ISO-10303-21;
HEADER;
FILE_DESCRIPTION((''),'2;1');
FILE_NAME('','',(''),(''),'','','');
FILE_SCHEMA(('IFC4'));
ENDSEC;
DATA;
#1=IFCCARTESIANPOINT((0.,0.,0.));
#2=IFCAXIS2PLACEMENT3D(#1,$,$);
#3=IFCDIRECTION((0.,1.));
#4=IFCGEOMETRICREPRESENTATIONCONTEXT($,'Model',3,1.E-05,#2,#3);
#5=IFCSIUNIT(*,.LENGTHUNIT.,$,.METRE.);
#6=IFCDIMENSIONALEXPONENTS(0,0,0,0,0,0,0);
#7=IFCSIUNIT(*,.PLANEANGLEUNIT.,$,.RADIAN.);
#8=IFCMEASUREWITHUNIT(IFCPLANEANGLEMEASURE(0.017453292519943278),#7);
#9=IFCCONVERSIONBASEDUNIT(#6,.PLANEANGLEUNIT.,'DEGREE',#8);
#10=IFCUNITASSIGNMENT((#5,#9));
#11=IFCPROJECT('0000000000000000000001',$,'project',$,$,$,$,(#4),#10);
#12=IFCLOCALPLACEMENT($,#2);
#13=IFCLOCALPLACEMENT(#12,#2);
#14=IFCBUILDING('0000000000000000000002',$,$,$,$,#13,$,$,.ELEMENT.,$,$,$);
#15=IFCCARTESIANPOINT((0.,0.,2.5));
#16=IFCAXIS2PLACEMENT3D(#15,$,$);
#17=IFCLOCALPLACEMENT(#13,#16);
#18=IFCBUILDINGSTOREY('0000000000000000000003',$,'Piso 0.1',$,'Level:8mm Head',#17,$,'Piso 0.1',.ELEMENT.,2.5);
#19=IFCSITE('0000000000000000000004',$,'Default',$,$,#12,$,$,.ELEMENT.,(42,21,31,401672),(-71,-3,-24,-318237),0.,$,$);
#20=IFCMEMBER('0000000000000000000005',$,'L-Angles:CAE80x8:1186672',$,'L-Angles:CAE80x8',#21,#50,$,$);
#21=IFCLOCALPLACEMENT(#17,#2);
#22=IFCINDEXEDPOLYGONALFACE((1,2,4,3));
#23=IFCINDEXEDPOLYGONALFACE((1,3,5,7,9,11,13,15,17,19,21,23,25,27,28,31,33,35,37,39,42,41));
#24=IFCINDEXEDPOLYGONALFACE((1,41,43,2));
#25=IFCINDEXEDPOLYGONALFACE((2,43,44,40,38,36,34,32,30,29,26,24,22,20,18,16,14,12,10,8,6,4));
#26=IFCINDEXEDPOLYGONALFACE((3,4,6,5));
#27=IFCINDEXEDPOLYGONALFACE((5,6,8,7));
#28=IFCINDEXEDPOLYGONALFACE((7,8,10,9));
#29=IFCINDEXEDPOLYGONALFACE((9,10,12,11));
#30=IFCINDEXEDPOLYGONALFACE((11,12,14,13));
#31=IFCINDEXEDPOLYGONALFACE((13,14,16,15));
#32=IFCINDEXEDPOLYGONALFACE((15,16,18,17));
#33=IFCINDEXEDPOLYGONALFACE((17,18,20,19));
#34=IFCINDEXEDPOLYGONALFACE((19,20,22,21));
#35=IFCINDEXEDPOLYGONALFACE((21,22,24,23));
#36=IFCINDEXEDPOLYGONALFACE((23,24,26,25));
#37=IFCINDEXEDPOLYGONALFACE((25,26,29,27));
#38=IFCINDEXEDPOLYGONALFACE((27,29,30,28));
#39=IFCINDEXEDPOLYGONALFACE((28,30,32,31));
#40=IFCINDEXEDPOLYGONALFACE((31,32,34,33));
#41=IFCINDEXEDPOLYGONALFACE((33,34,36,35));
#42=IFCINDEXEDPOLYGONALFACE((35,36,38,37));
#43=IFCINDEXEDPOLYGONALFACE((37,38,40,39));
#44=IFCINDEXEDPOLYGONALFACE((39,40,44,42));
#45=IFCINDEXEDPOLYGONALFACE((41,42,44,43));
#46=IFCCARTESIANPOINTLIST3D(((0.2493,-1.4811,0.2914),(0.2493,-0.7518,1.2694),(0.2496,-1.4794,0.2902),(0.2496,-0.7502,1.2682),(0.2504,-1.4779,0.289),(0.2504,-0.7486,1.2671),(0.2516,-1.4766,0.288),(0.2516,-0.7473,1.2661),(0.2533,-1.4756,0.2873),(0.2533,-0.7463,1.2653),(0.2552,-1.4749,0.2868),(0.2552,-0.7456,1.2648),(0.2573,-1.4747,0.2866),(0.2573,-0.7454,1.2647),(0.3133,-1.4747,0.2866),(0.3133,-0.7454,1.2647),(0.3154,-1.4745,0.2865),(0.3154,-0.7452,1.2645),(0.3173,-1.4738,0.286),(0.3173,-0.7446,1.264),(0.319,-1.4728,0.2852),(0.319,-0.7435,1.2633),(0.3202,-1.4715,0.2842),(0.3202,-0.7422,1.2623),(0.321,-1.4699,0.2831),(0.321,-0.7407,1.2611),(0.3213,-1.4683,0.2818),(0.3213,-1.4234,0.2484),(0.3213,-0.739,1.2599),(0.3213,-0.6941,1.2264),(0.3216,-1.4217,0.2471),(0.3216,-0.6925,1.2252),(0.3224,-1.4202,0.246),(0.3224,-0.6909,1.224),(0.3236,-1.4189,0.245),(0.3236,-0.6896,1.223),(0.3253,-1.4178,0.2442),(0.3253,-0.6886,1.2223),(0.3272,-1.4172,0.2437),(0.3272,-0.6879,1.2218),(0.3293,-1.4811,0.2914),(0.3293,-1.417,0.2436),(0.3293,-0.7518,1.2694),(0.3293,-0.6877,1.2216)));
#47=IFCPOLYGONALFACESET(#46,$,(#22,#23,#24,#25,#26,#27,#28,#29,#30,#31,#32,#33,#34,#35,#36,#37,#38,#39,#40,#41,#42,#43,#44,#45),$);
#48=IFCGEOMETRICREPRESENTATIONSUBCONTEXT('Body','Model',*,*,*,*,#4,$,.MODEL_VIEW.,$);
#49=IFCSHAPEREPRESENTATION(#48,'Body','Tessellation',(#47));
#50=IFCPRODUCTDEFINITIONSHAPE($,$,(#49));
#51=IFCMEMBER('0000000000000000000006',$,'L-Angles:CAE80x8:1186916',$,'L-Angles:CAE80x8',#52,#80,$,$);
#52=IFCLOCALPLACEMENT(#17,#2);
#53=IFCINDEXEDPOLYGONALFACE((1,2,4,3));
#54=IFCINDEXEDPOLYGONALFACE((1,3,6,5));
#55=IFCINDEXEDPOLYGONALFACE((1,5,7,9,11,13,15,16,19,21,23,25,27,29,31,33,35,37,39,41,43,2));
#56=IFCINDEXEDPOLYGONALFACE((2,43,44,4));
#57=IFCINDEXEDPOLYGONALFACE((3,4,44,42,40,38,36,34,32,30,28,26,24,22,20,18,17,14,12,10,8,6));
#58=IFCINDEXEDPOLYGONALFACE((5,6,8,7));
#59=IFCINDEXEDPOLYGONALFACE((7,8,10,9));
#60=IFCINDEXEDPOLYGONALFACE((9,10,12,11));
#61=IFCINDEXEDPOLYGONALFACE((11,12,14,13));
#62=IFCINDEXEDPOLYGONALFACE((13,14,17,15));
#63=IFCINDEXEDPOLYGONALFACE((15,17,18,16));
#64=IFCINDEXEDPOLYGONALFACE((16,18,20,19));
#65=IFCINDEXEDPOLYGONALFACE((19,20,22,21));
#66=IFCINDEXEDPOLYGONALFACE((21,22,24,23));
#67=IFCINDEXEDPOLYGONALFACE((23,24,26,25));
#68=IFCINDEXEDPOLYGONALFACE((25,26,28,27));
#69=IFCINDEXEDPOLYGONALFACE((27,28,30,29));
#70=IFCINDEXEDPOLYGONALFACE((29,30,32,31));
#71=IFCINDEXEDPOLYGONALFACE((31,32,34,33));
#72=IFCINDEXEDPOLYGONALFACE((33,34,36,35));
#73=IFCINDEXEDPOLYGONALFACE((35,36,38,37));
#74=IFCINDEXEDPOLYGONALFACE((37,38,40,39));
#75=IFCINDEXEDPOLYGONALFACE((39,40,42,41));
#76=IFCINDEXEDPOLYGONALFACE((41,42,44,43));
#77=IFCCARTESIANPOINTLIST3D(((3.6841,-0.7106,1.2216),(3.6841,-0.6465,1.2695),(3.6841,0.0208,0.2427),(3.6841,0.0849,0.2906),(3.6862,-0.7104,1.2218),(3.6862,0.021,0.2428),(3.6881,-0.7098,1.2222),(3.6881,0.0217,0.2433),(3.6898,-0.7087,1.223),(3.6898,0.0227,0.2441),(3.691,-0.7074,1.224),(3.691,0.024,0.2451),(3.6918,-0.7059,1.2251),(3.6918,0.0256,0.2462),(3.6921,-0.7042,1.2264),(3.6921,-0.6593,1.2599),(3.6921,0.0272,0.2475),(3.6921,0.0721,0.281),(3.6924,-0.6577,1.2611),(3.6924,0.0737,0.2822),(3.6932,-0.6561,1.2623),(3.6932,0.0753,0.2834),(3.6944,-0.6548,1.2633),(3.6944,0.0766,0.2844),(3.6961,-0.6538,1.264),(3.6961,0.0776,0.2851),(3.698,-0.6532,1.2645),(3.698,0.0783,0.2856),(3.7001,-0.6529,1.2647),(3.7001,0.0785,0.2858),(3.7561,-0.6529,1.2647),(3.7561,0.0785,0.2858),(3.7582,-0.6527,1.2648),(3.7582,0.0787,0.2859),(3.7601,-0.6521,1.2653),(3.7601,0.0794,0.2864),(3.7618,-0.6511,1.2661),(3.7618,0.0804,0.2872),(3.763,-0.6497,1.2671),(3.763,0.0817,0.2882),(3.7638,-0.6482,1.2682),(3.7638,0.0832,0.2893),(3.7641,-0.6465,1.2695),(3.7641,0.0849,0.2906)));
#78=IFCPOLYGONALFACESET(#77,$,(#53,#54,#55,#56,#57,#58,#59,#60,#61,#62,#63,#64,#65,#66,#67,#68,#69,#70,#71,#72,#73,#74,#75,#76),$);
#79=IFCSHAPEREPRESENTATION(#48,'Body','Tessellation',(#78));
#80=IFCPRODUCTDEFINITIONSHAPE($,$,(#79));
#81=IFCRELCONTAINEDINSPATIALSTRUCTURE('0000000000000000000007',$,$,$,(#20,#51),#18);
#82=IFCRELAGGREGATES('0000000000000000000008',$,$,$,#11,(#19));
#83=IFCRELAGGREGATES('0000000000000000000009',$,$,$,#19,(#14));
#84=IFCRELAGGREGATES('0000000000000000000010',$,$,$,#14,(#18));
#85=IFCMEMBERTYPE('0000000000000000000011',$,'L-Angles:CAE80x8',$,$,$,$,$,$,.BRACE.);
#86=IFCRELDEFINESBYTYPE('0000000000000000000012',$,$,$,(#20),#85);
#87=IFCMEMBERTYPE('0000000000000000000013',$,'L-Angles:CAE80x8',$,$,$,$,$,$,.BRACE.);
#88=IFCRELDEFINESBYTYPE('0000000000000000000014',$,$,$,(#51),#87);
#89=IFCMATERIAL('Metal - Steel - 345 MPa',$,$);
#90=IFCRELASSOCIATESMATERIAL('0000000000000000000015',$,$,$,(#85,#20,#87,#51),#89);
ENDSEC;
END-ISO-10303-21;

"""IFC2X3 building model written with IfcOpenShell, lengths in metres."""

from ifc_helpers import new_model, entity, si_unit, converted_unit, direction, frame, frame_2d, origin, place, context, subcontext, project, spatial, polyline, circle_curve, parameter, trimmed, segment, composite_curve, outline, extrude, source, transform, mapped, material, type_object, type_shapes, element, save


model = new_model("IFC2X3")

# Units and contexts
model_context = context("Model", 3, precision=1e-05, world=origin(), true_north=direction((0.0, 1.0)))
body_context = subcontext(model_context, "Body", "Model", "MODEL_VIEW")
ifc_project = project(units=[si_unit("LENGTHUNIT", "METRE"), converted_unit("PLANEANGLEUNIT", "DEGREE", entity("IfcPlaneAngleMeasure", 0.017453292519943278), si_unit("PLANEANGLEUNIT", "RADIAN"), dimensions=[0, 0, 0, 0, 0, 0, 0])], contexts=[model_context])

# Site, building, storey
site_placement = place(None, origin())
site = spatial("IfcSite", under=ifc_project, at=site_placement, Name="Default", CompositionType="ELEMENT", RefLatitude=(42, 21, 31, 401672), RefLongitude=(-71, -3, -24, -318237), RefElevation=0.0)
building_placement = place(site_placement, origin())
building = spatial("IfcBuilding", under=site, at=building_placement, CompositionType="ELEMENT")
storey_placement = place(building_placement, frame((0.0, 0.0, 2.5)))
storey = spatial("IfcBuildingStorey", under=building, at=storey_placement, Name="Piso 0.1", ObjectType="Level:8mm Head", LongName="Piso 0.1", CompositionType="ELEMENT", Elevation=2.5)

# Shared definitions
ifc_material_1 = material(Name="Metal - Steel - 345 MPa")

# Members
member_type_1 = type_object("IfcMemberType", Name="L-Angles:CAE80x8", PredefinedType="BRACE", material=ifc_material_1)
shared_shape_1 = source(origin(), body_context, "Body", "SweptSolid", [
    extrude(outline(composite_curve([segment(polyline([(-0.0263, -0.0263), (0.0537, -0.0263)]), True, "CONTINUOUS"), segment(trimmed(circle_curve(frame_2d((0.0457, -0.0263), x_axis=(1.0, 0.0)), 0.008), [parameter(0.0)], [parameter(90.0)], True, "PARAMETER"), True, "CONTINUOUS"), segment(polyline([(0.0457, -0.0183), (-0.0103, -0.0183)]), True, "CONTINUOUS"), segment(trimmed(circle_curve(frame_2d((-0.0103, -0.0103), x_axis=(1.0, 0.0)), 0.008), [parameter(180.0)], [parameter(270.0)], True, "PARAMETER"), False, "CONTINUOUS"), segment(polyline([(-0.0183, -0.0103), (-0.0183, 0.0457)]), True, "CONTINUOUS"), segment(trimmed(circle_curve(frame_2d((-0.0263, 0.0457), x_axis=(1.0, 0.0)), 0.008), [parameter(0.0)], [parameter(90.0)], True, "PARAMETER"), True, "CONTINUOUS"), segment(polyline([(-0.0263, 0.0537), (-0.0263, -0.0263)]), True, "CONTINUOUS")], self_intersect=False)), frame((-0.623, -0.0037, -0.0037), z_axis=(1.0, 0.0, 0.0), x_axis=(0.0, -1.0, 0.0)), (0.0, 0.0, 1.0), 1.22),
])
type_shapes(member_type_1, [shared_shape_1])
member_1_placement = place(storey_placement, frame((0.3067, -1.1061, 0.7565), z_axis=(0.0, -0.801673, 0.597763), x_axis=(0.0, -0.597763, -0.801673)))
element("IfcMember", 1, at=member_1_placement, inside=storey, type_object=member_type_1, material=ifc_material_1, Name="L-Angles:CAE80x8:1186672", ObjectType="L-Angles:CAE80x8", context=body_context, shape_type="MappedRepresentation", body=[
    mapped(shared_shape_1, transform((0.0, 0.0, 0.0), scale=1.0)),
])
member_type_2 = type_object("IfcMemberType", Name="L-Angles:CAE80x8", PredefinedType="BRACE", material=ifc_material_1)
shared_shape_2 = source(origin(), body_context, "Body", "SweptSolid", [
    extrude(outline(composite_curve([segment(polyline([(-0.0263, -0.0263), (0.0537, -0.0263)]), True, "CONTINUOUS"), segment(trimmed(circle_curve(frame_2d((0.0457, -0.0263), x_axis=(0.0, 1.0)), 0.008), [parameter(270.0)], [parameter(0.0)], True, "PARAMETER"), True, "CONTINUOUS"), segment(polyline([(0.0457, -0.0183), (-0.0103, -0.0183)]), True, "CONTINUOUS"), segment(trimmed(circle_curve(frame_2d((-0.0103, -0.0103), x_axis=(0.0, 1.0)), 0.008), [parameter(90.0)], [parameter(180.0)], True, "PARAMETER"), False, "CONTINUOUS"), segment(polyline([(-0.0183, -0.0103), (-0.0183, 0.0457)]), True, "CONTINUOUS"), segment(trimmed(circle_curve(frame_2d((-0.0263, 0.0457), x_axis=(0.0, 1.0)), 0.008), [parameter(270.0)], [parameter(360.0)], True, "PARAMETER"), True, "CONTINUOUS"), segment(polyline([(-0.0263, 0.0537), (-0.0263, -0.0263)]), True, "CONTINUOUS")], self_intersect=False)), frame((-0.5985, 0.0037, -0.0037), z_axis=(1.0, 0.0, 0.0), x_axis=(0.0, 0.0, -1.0)), (0.0, 0.0, 1.0), 1.222),
])
type_shapes(member_type_2, [shared_shape_2])
member_2_placement = place(storey_placement, frame((3.7067, -0.2914, 0.7565), z_axis=(0.0, 0.801082, 0.598555), x_axis=(0.0, -0.598555, 0.801082)))
element("IfcMember", 2, at=member_2_placement, inside=storey, type_object=member_type_2, material=ifc_material_1, Name="L-Angles:CAE80x8:1186916", ObjectType="L-Angles:CAE80x8", context=body_context, shape_type="MappedRepresentation", body=[
    mapped(shared_shape_2, transform((0.0, 0.0, 0.0), scale=1.0)),
])

save(model, "model.ifc")
